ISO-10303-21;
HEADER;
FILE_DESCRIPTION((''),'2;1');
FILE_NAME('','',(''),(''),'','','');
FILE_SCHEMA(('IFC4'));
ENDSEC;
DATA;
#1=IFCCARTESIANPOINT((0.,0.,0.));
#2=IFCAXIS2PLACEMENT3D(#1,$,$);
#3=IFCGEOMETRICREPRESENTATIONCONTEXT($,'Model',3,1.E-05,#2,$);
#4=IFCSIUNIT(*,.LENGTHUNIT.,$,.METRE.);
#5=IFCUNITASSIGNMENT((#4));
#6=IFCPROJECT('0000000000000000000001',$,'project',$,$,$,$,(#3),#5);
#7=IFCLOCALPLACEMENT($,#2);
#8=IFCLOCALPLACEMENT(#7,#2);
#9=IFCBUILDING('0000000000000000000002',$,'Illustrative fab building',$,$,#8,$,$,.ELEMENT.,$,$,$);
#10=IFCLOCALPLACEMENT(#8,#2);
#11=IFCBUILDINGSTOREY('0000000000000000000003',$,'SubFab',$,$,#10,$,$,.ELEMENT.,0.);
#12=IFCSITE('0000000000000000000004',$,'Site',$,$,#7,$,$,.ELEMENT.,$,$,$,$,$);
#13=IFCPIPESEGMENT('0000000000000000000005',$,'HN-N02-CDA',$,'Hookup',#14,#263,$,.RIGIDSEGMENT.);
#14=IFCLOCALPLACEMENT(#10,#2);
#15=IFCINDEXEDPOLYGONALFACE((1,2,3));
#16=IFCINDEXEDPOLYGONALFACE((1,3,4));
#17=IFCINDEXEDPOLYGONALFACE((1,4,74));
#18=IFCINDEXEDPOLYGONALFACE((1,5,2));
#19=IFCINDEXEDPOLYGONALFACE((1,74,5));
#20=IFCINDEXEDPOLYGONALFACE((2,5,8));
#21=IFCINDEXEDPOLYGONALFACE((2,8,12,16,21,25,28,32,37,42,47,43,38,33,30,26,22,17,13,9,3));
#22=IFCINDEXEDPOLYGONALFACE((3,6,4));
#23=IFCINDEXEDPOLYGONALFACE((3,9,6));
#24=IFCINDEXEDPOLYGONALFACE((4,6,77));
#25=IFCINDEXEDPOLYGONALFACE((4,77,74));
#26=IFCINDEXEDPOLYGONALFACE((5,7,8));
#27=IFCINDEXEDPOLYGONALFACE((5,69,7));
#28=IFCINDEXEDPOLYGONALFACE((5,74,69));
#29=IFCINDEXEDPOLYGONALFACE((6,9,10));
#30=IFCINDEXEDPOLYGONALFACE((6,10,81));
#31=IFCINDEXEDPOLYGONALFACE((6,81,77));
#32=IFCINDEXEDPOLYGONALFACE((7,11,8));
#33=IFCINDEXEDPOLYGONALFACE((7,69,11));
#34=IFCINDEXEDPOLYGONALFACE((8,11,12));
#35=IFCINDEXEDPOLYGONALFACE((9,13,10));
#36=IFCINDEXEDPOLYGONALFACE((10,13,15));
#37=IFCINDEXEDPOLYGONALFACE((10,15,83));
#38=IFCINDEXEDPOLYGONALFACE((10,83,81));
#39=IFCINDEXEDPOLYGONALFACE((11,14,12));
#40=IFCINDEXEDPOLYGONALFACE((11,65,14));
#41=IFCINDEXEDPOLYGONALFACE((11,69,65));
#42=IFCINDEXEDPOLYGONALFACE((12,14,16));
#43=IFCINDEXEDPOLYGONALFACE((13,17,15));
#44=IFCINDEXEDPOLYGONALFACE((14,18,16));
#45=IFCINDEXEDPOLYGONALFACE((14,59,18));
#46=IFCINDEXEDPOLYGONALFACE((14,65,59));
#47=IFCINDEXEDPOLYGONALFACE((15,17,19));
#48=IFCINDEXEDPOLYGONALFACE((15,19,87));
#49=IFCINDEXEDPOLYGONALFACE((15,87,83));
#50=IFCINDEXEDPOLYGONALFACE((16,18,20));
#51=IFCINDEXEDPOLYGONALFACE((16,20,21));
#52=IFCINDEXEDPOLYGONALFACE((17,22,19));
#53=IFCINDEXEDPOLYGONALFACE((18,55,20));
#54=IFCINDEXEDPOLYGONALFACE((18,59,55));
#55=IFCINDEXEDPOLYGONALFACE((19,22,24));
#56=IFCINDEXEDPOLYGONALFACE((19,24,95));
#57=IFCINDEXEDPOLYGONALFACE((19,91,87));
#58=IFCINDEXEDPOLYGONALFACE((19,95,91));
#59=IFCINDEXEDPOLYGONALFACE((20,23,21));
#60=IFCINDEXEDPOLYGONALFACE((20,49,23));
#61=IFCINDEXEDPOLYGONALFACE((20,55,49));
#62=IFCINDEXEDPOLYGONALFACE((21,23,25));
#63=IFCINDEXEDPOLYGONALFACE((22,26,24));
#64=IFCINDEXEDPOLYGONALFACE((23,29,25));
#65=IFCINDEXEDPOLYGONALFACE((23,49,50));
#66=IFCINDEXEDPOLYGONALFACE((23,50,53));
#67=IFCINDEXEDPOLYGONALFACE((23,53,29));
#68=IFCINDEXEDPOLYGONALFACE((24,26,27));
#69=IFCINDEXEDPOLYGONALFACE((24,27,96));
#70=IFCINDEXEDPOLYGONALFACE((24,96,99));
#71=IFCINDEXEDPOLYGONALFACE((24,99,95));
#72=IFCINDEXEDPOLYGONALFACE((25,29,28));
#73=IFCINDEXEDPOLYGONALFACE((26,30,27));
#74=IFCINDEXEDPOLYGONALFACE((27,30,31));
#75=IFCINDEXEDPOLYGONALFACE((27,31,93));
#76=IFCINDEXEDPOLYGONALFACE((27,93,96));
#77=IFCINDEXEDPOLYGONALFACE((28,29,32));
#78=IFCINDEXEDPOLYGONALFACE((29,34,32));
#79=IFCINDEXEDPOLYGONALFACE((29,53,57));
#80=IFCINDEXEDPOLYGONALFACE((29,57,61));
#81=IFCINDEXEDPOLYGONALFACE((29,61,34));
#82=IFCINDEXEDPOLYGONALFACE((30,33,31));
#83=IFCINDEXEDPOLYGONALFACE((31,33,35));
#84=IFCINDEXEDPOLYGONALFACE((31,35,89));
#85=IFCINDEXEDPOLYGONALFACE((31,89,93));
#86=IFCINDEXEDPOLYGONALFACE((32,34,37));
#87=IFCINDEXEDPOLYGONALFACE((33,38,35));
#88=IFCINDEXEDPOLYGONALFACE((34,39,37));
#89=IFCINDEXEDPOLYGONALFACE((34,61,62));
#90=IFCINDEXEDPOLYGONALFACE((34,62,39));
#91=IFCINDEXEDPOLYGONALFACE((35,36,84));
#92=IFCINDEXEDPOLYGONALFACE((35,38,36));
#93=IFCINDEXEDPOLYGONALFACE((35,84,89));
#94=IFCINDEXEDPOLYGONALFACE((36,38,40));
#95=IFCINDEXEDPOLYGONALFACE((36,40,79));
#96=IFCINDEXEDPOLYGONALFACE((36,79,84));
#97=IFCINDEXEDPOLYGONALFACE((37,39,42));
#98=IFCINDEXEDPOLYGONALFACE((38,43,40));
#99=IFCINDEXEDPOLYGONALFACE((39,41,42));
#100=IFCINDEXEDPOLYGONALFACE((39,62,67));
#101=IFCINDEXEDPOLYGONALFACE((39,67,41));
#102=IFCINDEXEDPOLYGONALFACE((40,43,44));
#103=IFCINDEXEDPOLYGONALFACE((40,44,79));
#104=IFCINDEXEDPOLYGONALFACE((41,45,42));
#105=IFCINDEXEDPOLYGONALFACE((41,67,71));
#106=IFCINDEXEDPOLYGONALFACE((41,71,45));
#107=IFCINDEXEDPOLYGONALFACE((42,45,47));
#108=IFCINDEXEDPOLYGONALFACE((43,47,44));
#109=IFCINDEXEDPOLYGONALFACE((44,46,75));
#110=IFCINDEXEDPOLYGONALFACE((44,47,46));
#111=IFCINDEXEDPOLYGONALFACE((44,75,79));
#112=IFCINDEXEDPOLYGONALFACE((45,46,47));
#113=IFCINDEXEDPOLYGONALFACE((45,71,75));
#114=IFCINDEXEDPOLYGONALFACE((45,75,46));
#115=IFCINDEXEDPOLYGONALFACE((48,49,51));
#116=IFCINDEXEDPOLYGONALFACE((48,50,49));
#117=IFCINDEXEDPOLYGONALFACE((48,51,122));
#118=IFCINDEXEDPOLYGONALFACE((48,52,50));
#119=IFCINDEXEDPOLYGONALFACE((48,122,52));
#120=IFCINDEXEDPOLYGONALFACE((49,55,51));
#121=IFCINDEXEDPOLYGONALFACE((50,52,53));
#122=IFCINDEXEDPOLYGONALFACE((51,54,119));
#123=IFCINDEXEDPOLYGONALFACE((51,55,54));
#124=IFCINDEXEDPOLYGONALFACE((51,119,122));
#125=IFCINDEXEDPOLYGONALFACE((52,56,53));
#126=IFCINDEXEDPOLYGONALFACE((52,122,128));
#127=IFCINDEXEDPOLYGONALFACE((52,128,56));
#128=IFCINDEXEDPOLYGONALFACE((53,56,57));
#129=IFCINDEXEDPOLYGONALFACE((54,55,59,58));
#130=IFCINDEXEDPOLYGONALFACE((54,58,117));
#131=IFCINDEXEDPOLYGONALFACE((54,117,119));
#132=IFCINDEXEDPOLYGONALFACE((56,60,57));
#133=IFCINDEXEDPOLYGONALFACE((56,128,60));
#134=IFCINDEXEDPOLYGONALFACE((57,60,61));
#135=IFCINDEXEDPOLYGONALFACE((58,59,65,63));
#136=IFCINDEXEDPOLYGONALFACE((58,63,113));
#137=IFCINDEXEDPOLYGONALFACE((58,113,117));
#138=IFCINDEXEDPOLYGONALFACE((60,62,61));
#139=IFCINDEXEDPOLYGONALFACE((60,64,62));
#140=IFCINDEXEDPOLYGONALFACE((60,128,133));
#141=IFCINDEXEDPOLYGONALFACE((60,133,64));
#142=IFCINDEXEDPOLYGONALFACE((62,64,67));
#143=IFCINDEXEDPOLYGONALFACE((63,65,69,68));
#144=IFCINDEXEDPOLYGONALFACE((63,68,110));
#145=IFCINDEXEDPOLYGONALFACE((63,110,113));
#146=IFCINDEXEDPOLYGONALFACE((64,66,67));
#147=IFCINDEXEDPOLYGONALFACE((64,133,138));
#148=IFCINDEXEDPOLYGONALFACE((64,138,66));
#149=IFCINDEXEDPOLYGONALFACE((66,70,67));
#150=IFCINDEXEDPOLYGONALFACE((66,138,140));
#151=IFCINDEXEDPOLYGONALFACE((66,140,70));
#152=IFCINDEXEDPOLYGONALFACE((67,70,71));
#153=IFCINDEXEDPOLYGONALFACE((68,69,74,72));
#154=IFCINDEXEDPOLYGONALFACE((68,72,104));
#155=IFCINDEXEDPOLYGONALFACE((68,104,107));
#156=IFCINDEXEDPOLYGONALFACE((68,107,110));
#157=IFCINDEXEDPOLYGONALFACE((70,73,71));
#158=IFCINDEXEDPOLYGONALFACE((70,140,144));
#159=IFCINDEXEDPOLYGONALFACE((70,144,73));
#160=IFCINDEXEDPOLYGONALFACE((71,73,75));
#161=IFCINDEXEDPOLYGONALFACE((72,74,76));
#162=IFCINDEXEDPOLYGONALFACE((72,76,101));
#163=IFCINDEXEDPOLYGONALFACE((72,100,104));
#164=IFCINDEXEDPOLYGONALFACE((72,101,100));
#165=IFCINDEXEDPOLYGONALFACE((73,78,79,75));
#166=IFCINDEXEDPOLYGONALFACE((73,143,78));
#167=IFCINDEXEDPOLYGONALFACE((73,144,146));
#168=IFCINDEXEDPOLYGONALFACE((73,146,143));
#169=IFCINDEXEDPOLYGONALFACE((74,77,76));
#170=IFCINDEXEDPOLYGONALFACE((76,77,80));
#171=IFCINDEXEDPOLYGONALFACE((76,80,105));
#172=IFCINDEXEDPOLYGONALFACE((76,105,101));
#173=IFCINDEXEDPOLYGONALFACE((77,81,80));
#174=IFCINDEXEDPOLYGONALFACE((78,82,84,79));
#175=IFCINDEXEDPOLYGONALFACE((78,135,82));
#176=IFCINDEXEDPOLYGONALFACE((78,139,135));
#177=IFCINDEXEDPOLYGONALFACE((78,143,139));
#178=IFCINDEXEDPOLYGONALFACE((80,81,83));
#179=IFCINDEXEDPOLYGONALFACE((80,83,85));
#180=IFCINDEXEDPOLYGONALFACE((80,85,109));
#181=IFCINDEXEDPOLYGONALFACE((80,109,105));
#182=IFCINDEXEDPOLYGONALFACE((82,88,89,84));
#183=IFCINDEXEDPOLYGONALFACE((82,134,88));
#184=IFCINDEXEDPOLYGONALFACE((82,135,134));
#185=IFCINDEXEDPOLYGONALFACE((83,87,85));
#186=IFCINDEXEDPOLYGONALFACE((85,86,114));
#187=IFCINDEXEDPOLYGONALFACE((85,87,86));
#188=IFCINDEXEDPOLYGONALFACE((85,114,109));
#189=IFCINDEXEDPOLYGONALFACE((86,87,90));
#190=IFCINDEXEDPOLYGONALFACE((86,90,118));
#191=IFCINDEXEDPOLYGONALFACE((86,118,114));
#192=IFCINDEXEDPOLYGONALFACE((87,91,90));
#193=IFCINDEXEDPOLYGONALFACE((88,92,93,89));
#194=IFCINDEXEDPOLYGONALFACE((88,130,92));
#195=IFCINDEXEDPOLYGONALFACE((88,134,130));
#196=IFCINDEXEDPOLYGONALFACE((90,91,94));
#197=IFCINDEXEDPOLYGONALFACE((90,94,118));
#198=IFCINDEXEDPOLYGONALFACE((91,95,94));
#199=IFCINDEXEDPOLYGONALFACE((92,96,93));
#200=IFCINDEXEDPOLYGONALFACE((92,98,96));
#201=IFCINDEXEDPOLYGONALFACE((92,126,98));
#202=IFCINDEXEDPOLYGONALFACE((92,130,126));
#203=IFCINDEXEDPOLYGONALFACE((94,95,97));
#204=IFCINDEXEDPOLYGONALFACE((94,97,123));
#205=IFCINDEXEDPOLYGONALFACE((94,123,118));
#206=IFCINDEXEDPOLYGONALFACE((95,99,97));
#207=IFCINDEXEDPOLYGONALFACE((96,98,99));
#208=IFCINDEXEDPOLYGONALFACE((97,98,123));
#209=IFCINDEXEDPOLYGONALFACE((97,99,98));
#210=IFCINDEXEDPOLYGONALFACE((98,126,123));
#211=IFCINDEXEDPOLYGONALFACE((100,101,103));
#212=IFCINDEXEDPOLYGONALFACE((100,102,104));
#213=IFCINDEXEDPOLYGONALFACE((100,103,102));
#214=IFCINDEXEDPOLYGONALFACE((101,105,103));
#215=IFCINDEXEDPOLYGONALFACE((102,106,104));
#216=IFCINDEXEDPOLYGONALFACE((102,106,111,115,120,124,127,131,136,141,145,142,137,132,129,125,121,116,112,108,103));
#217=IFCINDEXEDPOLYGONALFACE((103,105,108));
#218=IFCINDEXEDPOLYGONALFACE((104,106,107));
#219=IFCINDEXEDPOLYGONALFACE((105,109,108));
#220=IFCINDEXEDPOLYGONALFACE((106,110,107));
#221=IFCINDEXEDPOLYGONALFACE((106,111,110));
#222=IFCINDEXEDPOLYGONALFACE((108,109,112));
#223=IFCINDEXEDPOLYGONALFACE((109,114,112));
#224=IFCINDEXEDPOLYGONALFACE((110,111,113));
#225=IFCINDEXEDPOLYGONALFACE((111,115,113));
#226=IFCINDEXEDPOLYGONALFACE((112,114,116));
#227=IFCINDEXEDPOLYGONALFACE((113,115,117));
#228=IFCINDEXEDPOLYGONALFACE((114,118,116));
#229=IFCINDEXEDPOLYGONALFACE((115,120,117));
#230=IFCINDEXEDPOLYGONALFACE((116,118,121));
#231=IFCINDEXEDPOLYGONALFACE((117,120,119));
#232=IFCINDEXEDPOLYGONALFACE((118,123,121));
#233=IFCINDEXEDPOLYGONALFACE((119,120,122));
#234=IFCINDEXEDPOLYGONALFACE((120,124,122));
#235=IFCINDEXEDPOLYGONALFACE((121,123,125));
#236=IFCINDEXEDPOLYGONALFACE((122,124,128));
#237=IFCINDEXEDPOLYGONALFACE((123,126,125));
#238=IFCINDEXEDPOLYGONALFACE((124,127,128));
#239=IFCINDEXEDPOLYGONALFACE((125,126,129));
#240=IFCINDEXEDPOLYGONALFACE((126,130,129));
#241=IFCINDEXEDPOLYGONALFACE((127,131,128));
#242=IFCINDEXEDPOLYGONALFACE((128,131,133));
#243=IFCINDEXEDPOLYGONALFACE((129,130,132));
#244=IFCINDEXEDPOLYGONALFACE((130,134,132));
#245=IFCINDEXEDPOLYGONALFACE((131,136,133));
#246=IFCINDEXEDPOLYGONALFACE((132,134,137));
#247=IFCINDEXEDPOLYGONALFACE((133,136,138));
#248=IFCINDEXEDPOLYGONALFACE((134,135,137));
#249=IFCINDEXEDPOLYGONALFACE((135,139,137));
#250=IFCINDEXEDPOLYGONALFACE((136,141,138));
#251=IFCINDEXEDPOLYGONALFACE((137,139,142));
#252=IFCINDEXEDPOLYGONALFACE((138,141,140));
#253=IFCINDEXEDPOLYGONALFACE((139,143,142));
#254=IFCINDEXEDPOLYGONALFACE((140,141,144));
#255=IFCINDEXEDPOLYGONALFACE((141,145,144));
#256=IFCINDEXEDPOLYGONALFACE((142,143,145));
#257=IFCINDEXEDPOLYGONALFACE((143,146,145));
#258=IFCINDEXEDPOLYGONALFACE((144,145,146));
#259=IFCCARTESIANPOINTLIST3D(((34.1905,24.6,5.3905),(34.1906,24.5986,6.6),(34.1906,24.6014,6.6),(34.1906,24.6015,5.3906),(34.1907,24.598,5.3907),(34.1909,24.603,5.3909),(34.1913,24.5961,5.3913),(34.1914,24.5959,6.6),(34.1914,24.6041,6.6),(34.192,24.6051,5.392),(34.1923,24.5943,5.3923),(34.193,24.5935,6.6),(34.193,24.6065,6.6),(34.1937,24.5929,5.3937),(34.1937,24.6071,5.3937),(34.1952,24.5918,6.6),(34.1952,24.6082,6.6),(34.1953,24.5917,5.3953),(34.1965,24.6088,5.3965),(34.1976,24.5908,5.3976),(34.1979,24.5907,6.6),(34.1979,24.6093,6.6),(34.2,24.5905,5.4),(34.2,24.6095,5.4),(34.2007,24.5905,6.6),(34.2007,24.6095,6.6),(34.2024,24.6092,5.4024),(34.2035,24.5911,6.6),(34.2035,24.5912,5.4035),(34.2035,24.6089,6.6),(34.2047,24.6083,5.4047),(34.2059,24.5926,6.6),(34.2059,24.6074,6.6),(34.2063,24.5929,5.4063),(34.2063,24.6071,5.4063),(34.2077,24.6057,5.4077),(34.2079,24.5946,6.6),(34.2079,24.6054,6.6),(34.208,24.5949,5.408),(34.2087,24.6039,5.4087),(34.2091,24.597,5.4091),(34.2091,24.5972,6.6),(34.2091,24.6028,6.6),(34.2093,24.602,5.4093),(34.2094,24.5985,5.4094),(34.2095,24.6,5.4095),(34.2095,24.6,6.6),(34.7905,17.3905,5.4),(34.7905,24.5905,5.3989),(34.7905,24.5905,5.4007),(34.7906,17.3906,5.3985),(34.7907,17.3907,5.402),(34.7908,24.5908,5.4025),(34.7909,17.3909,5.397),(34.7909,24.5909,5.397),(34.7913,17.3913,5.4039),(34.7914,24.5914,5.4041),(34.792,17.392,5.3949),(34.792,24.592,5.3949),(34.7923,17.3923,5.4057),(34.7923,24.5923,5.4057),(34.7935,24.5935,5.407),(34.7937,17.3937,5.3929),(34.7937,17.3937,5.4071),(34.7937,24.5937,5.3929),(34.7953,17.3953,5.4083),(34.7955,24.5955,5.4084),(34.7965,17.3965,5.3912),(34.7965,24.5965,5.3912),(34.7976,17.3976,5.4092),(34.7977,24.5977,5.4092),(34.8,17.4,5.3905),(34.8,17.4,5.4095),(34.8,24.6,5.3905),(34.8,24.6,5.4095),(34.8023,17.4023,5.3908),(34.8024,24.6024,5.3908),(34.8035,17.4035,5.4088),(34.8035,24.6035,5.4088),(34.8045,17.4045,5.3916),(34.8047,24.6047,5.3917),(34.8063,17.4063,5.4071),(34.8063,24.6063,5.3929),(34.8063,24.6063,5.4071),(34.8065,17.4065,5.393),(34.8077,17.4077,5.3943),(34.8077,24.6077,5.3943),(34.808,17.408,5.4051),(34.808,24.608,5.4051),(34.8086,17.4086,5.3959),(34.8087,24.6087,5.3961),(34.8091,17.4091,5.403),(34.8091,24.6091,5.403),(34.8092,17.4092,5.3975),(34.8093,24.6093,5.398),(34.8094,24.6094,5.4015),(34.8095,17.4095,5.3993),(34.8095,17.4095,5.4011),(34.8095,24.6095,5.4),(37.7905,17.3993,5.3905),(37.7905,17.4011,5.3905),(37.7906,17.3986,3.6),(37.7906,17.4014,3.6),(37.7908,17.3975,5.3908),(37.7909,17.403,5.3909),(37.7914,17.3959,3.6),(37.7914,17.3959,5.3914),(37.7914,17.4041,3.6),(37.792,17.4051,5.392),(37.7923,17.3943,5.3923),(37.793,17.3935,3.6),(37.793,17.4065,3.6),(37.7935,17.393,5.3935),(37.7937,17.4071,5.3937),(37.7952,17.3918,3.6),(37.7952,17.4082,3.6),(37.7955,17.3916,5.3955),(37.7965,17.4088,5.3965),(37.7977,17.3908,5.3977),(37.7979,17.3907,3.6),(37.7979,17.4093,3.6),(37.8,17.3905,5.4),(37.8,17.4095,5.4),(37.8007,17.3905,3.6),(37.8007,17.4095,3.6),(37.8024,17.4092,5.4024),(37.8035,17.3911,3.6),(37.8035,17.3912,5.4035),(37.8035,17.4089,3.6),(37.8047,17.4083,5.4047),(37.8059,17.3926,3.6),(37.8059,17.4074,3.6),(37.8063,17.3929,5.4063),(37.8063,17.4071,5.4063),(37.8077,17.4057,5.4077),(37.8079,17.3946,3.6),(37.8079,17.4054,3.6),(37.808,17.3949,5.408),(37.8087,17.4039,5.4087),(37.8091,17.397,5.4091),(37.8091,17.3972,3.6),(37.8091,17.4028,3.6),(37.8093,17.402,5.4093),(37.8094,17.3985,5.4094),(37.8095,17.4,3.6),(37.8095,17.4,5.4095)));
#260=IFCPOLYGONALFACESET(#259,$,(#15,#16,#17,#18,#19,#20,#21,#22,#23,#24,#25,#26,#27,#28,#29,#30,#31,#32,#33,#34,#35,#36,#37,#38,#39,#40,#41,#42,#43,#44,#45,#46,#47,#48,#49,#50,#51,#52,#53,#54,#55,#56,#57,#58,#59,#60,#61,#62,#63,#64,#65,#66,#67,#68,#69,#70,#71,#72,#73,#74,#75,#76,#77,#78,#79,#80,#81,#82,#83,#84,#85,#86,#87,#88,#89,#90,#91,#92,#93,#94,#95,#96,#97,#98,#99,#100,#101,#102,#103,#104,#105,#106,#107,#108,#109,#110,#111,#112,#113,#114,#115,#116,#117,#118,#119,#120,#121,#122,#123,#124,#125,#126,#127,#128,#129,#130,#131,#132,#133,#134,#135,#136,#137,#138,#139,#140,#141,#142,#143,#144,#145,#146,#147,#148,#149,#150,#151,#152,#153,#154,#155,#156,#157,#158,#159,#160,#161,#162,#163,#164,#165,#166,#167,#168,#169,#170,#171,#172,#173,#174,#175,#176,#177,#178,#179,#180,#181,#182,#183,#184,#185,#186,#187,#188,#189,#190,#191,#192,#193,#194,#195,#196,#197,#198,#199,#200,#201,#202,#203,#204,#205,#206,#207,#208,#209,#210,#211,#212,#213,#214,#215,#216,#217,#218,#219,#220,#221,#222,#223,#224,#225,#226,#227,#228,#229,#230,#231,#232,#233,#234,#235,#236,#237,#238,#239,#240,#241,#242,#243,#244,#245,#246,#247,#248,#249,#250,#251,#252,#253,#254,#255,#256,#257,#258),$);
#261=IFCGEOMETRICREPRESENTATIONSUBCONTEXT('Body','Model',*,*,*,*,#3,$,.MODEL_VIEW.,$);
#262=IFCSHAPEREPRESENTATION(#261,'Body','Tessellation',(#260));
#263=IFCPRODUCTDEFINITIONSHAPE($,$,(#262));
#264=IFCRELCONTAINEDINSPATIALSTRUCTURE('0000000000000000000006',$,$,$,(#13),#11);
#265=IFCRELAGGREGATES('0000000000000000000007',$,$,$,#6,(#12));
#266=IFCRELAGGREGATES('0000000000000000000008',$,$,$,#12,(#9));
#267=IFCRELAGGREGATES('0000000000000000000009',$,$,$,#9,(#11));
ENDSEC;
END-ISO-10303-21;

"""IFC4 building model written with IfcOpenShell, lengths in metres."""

from ifc_helpers import new_model, entity, si_unit, origin, place, context, subcontext, project, spatial, element, save


model = new_model("IFC4")

# Units and contexts
model_context = context("Model", 3, precision=1e-05, world=origin())
body_context = subcontext(model_context, "Body", "Model", "MODEL_VIEW")
ifc_project = project(units=[si_unit("LENGTHUNIT", "METRE")], contexts=[model_context])

# Site, building, storey
site_placement = place(None, origin())
site = spatial("IfcSite", under=ifc_project, at=site_placement, Name="Site", CompositionType="ELEMENT")
building_placement = place(site_placement, origin())
building = spatial("IfcBuilding", under=site, at=building_placement, Name="Illustrative fab building", CompositionType="ELEMENT")
storey_placement = place(building_placement, origin())
storey = spatial("IfcBuildingStorey", under=building, at=storey_placement, Name="SubFab", CompositionType="ELEMENT", Elevation=0.0)

# Pipe segment
pipe_segment_1_placement = place(storey_placement, origin())
element("IfcPipeSegment", 1, at=pipe_segment_1_placement, inside=storey, Name="HN-N02-CDA", ObjectType="Hookup", PredefinedType="RIGIDSEGMENT", context=body_context, shape_type="AdvancedSweptSolid", body=[
    entity("IfcSweptDiskSolid", entity("IfcPolyline", [entity("IfcCartesianPoint", [37.8, 17.4, 3.6]), entity("IfcCartesianPoint", [37.8, 17.4, 5.4]), entity("IfcCartesianPoint", [34.8, 17.4, 5.4]), entity("IfcCartesianPoint", [34.8, 24.6, 5.4]), entity("IfcCartesianPoint", [34.2, 24.6, 5.4]), entity("IfcCartesianPoint", [34.2, 24.6, 6.6])]), 0.0095),
])

save(model, "model.ifc")
